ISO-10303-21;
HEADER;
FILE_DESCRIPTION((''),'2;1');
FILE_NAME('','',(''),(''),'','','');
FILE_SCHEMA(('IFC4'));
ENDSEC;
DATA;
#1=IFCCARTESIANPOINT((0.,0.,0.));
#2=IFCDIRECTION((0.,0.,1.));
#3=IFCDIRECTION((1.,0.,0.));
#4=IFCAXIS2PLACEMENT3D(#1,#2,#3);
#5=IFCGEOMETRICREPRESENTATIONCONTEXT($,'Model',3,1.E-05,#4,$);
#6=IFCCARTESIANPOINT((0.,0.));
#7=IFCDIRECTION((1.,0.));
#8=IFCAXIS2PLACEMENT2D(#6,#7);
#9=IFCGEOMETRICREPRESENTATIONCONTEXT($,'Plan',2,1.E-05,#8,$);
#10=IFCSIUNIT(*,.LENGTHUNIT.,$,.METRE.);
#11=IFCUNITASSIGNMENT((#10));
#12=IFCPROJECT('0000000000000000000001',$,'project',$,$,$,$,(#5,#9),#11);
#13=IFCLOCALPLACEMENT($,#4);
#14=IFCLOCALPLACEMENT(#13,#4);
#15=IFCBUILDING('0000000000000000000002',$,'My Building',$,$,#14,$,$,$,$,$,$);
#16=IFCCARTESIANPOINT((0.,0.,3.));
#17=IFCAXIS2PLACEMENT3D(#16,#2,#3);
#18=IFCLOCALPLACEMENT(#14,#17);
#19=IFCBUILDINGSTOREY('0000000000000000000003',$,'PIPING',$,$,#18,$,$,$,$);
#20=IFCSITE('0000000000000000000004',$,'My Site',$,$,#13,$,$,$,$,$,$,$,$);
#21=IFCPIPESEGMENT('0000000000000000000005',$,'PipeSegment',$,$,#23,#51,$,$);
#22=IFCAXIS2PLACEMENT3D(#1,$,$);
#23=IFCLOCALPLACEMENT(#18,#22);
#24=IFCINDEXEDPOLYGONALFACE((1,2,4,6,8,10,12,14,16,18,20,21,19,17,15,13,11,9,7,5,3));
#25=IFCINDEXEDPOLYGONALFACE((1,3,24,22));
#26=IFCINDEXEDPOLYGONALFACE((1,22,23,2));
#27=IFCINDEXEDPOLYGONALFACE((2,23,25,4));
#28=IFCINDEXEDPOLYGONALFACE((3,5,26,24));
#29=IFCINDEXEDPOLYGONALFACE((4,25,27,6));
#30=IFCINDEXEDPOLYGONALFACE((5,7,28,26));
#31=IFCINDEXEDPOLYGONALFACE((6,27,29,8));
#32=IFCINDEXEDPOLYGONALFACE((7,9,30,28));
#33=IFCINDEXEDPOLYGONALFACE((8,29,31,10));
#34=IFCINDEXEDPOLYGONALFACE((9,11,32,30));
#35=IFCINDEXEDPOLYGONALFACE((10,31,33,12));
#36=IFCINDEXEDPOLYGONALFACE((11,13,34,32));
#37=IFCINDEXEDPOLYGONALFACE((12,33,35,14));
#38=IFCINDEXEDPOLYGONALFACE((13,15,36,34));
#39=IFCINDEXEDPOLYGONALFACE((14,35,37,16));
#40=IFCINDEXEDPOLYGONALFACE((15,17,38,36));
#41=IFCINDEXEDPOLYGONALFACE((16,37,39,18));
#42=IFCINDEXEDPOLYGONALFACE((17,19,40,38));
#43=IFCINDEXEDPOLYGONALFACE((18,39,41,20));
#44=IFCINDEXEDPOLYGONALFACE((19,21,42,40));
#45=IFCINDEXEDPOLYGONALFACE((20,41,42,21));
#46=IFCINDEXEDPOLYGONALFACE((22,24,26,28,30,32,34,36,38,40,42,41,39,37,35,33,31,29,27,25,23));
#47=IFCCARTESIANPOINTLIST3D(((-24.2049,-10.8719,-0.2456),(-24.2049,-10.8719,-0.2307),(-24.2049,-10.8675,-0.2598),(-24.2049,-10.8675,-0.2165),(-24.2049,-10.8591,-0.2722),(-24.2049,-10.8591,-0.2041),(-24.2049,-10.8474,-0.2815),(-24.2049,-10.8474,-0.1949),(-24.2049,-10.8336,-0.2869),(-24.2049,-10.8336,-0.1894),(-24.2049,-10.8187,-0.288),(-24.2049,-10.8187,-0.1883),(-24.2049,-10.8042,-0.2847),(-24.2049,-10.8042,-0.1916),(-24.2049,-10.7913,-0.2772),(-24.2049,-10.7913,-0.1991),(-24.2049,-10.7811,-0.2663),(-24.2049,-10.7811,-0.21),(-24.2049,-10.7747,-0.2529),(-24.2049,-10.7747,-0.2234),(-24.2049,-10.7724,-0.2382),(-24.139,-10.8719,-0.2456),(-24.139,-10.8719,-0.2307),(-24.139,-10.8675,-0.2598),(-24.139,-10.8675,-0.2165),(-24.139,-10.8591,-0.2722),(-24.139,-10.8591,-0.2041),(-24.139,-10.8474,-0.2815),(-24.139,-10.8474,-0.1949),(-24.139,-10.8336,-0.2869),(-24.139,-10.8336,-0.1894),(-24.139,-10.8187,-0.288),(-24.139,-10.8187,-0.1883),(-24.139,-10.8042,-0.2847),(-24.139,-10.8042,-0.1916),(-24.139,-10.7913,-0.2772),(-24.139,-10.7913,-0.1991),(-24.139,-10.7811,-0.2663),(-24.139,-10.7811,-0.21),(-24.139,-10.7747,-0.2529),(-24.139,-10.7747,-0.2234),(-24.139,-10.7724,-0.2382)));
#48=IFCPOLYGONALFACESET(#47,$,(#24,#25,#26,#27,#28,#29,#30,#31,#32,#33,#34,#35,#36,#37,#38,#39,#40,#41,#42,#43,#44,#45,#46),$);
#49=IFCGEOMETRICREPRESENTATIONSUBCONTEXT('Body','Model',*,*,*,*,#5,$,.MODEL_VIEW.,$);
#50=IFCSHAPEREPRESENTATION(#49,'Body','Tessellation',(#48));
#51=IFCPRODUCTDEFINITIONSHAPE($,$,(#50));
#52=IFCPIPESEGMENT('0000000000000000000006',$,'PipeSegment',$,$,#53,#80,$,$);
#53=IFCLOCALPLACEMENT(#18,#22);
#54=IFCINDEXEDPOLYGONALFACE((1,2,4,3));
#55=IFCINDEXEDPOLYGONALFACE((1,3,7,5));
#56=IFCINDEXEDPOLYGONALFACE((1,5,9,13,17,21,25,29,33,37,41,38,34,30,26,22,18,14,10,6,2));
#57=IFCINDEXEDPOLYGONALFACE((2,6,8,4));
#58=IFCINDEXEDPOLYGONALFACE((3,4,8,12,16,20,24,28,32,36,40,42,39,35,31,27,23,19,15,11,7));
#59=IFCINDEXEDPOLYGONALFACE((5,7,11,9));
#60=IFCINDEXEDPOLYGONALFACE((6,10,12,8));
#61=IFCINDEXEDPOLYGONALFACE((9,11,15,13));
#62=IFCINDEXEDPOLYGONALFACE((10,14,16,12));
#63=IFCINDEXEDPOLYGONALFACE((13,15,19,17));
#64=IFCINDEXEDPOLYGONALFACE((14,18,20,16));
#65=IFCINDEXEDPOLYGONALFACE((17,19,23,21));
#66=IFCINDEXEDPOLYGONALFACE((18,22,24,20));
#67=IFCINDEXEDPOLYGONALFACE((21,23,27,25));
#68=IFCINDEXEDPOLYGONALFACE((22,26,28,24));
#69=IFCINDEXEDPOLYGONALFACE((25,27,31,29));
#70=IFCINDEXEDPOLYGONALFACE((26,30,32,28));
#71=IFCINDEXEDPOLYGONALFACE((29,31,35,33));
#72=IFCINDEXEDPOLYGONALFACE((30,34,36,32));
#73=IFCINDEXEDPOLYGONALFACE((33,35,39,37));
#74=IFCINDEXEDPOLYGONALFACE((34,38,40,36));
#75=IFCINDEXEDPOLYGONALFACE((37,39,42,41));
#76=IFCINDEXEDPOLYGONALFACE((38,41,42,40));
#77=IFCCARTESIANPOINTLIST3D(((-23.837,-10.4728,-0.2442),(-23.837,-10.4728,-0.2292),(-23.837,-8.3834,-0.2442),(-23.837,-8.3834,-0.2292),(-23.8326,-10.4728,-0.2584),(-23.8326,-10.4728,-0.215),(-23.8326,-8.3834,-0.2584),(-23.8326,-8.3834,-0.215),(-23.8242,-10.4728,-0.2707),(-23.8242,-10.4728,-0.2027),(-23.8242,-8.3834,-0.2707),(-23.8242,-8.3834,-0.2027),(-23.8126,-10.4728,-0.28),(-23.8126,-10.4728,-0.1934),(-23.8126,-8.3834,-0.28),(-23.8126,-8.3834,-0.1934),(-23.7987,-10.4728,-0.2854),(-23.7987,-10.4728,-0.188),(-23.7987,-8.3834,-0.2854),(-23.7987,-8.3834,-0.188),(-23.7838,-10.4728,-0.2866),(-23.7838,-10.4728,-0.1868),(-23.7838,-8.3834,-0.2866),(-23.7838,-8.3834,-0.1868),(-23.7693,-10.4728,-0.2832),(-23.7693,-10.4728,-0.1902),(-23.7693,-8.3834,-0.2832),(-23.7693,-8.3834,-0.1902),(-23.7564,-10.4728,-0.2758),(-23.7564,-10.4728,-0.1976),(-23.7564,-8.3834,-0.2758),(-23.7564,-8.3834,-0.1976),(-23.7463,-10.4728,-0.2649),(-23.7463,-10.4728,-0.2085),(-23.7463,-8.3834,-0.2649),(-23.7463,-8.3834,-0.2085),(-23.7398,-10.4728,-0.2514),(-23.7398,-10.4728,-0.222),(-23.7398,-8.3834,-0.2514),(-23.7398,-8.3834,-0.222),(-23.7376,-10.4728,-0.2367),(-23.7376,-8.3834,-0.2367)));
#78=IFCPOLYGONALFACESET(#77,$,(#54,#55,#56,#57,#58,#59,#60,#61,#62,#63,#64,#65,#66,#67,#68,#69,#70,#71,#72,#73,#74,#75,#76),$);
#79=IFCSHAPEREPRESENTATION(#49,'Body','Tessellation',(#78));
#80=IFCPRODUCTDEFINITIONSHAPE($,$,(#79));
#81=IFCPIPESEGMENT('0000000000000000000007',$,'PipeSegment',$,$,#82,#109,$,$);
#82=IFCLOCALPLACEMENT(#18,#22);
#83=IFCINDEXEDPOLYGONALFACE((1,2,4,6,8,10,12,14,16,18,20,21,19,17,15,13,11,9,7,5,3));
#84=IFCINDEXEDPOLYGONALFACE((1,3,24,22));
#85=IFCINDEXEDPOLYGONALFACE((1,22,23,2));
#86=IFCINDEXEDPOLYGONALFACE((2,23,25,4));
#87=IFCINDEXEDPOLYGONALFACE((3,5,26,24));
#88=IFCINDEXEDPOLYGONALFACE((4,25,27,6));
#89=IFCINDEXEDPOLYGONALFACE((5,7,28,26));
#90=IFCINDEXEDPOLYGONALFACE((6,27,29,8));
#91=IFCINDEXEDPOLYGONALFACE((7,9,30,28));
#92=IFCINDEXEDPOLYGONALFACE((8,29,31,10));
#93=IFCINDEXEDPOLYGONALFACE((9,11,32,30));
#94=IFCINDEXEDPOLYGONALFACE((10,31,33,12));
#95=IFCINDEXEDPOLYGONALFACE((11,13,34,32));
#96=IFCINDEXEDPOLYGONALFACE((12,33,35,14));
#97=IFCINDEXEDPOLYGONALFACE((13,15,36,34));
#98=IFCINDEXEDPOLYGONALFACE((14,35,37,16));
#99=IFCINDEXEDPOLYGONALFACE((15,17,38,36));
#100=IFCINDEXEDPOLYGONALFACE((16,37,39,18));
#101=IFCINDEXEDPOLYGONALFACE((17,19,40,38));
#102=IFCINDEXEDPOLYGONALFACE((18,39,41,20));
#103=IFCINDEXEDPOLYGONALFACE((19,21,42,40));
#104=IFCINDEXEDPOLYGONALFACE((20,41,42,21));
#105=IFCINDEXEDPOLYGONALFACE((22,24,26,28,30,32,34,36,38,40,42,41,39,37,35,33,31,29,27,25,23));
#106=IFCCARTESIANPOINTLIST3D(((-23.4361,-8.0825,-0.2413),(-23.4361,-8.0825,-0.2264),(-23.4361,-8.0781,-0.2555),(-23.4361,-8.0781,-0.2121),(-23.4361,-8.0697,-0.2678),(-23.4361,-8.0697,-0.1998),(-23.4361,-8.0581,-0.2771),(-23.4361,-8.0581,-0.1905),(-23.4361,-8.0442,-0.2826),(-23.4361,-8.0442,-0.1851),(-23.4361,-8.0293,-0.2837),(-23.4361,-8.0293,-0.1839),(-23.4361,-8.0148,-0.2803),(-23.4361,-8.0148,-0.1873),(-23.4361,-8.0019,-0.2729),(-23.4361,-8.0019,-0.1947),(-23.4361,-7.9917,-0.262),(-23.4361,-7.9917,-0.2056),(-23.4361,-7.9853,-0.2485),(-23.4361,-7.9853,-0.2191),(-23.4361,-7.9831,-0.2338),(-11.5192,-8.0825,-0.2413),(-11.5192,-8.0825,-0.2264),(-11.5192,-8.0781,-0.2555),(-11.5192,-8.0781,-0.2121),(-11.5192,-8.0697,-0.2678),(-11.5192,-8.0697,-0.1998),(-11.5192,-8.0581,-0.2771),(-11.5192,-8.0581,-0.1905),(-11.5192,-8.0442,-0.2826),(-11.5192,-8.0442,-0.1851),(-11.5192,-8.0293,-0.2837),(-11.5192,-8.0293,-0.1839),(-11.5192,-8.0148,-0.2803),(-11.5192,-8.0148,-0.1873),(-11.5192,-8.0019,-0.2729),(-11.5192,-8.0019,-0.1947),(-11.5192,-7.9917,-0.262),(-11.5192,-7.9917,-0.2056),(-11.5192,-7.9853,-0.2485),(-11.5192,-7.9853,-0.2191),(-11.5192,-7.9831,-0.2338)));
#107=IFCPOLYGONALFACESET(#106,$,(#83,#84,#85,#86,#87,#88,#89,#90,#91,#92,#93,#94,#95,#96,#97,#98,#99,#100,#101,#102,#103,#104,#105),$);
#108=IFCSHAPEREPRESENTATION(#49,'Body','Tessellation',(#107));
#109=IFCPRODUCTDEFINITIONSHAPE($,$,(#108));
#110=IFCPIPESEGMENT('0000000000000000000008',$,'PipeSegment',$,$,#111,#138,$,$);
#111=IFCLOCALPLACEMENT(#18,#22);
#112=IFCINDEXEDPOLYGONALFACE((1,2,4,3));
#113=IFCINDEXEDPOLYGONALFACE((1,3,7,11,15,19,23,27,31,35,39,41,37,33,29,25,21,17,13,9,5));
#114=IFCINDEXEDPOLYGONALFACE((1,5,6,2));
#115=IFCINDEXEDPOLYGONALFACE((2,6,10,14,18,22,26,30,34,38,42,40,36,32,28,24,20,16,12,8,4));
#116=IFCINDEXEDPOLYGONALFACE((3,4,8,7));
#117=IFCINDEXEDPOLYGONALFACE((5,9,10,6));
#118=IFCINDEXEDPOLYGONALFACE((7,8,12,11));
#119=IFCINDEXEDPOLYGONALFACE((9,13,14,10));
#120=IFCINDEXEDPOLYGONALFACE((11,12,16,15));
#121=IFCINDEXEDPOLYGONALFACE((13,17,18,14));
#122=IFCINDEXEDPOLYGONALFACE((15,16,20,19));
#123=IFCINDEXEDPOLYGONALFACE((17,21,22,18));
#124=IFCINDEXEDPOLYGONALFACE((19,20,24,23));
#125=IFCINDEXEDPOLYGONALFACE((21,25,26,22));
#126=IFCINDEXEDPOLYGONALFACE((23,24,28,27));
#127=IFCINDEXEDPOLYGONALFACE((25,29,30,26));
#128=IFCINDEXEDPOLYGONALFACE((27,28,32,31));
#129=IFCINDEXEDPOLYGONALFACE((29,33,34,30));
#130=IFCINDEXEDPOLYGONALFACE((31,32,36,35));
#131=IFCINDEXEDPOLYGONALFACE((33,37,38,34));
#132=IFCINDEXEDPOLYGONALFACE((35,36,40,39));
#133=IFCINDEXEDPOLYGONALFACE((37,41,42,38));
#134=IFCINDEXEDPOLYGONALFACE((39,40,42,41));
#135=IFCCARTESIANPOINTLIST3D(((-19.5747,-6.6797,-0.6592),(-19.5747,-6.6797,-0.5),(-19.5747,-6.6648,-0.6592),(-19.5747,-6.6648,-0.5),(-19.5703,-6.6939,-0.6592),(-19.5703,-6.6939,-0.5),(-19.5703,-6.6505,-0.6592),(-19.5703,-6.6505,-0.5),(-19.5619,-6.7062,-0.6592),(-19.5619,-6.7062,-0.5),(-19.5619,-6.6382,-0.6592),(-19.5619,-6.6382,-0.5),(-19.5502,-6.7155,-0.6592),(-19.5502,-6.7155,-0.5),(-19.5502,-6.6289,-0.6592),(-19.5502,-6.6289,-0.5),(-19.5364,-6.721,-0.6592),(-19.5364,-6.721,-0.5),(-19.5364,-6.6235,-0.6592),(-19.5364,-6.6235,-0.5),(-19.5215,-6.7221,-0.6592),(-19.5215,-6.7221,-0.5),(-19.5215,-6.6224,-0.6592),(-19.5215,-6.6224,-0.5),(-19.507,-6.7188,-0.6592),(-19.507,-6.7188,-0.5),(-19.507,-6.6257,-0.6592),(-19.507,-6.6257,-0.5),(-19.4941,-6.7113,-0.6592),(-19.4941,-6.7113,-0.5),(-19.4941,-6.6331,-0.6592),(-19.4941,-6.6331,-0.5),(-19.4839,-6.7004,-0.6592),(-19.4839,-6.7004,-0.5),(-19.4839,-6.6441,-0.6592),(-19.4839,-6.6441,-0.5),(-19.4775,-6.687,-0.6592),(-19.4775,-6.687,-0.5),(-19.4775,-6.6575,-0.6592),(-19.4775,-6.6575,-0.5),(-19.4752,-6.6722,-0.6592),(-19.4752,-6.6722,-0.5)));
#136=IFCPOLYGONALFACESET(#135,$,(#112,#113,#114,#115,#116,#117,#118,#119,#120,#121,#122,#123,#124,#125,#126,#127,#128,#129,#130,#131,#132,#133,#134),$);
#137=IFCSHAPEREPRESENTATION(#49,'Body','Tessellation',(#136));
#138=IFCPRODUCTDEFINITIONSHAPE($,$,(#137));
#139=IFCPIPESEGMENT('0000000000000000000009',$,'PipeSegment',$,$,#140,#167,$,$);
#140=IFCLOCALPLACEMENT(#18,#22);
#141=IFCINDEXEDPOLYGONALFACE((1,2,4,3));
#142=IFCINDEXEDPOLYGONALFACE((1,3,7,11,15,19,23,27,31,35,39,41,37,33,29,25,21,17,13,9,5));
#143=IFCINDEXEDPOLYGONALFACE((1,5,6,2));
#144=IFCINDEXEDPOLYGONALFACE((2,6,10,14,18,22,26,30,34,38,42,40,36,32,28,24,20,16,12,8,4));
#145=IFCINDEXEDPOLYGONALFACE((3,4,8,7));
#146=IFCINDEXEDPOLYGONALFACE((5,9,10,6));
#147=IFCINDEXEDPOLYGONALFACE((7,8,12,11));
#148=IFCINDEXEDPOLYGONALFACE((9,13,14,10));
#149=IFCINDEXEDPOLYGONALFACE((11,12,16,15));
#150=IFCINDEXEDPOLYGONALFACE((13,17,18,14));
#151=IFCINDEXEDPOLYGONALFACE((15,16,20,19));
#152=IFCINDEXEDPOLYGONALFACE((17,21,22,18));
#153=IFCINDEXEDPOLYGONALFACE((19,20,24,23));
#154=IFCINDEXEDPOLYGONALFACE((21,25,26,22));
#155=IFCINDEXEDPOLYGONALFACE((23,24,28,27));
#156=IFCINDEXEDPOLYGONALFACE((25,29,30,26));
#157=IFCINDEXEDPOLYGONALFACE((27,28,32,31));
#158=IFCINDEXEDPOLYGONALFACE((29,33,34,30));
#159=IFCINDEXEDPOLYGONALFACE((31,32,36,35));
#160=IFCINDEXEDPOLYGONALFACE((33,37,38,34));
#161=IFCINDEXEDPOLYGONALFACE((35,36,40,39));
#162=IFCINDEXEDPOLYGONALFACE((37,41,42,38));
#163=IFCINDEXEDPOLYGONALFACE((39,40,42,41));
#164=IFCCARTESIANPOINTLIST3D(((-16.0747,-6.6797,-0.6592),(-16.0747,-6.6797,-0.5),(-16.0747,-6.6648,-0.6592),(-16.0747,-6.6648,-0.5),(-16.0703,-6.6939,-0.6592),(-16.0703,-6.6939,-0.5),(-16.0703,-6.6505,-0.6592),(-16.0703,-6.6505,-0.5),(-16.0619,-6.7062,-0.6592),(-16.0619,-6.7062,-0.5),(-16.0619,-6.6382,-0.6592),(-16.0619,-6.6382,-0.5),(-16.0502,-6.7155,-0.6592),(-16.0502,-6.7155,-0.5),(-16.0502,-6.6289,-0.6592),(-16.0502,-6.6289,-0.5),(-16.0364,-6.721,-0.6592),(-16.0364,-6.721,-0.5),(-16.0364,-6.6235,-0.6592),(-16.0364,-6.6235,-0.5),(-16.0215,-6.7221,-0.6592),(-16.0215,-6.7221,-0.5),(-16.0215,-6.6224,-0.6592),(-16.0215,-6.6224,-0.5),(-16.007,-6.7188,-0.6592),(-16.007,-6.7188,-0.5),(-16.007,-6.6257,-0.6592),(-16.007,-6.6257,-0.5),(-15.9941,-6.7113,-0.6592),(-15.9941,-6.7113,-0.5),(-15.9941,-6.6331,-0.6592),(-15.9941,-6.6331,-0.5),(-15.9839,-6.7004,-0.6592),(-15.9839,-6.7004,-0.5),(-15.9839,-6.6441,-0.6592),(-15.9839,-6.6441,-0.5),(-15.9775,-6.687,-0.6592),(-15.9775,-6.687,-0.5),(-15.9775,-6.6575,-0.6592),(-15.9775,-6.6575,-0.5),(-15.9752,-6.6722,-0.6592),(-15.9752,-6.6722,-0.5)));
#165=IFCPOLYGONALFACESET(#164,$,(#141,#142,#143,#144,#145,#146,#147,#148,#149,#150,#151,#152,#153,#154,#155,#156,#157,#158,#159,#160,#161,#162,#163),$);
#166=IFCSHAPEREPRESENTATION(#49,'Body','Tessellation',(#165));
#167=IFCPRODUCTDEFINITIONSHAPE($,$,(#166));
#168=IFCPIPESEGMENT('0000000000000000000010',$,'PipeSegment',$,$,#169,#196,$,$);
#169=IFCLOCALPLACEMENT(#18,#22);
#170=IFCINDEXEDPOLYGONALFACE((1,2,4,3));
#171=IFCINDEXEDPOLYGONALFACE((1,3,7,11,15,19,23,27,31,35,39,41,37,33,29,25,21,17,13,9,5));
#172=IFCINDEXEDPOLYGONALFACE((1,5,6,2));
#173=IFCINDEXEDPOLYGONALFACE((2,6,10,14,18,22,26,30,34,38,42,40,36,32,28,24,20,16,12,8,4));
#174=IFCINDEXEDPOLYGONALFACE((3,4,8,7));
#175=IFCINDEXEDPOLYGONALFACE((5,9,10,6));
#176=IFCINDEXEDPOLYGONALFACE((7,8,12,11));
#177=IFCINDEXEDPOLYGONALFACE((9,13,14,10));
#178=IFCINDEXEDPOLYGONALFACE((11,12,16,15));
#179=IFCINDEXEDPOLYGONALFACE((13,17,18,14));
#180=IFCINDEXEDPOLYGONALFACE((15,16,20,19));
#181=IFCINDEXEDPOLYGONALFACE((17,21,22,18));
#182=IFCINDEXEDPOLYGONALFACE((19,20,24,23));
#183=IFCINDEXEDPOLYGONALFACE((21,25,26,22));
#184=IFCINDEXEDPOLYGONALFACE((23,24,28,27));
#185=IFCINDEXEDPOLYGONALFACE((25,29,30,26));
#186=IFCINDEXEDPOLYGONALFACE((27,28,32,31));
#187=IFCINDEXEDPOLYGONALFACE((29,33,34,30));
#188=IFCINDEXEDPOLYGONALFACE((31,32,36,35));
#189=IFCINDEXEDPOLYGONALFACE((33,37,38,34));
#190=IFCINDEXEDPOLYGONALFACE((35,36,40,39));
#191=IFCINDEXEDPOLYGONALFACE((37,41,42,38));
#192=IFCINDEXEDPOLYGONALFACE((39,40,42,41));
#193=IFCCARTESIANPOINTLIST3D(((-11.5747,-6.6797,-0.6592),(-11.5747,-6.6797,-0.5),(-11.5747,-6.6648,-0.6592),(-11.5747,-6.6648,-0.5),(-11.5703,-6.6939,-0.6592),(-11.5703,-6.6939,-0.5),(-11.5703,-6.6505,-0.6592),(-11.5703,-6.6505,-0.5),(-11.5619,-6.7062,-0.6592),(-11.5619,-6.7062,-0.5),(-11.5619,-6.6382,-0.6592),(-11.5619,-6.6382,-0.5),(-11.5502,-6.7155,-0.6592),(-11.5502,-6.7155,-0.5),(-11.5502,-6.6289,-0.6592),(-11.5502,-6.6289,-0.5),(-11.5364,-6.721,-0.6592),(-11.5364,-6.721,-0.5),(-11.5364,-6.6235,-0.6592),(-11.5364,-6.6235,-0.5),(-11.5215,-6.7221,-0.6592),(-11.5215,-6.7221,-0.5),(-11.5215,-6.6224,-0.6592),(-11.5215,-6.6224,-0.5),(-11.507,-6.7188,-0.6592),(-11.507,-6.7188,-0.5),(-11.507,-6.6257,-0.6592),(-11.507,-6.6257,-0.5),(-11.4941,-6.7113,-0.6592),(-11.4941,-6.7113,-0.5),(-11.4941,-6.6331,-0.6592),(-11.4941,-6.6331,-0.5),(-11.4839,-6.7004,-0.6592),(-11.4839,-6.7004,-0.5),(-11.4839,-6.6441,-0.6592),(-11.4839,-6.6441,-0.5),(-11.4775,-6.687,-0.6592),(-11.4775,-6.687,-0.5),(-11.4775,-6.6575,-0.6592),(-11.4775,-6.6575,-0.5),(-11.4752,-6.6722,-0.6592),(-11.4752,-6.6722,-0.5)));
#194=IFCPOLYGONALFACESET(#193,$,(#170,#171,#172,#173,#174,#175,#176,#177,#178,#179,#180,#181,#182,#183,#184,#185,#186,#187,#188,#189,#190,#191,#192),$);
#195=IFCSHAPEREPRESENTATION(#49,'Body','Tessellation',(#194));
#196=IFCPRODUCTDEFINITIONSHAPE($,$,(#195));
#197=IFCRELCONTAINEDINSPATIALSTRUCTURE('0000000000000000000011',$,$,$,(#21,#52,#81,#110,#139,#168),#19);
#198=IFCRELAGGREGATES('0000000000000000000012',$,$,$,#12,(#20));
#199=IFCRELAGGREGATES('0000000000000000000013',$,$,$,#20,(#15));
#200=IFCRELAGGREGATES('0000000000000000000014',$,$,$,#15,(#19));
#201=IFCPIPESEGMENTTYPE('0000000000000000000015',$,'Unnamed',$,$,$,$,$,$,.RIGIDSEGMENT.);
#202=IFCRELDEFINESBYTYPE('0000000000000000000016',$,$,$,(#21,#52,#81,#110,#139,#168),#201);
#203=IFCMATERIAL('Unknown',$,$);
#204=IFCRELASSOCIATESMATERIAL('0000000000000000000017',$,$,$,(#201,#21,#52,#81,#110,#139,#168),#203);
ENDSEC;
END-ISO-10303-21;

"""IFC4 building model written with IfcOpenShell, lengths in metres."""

from ifc_helpers import new_model, si_unit, frame, origin_with_axes, origin_2d_with_axis, place, context, subcontext, project, spatial, circle, extrude, material, material_profile, profile_set, profile_usage, type_object, element, save


model = new_model("IFC4")

# Units and contexts
model_context = context("Model", 3, precision=1e-05, world=origin_with_axes())
plan_context = context("Plan", 2, precision=1e-05, world=origin_2d_with_axis())
body_context = subcontext(model_context, "Body", "Model", "MODEL_VIEW")
ifc_project = project(units=[si_unit("LENGTHUNIT", "METRE")], contexts=[model_context, plan_context])

# Site, building, storey
site_placement = place(None, origin_with_axes())
site = spatial("IfcSite", under=ifc_project, at=site_placement, Name="My Site")
building_placement = place(site_placement, origin_with_axes())
building = spatial("IfcBuilding", under=site, at=building_placement, Name="My Building")
storey_placement = place(building_placement, frame((0.0, 0.0, 3.0), z_axis=(0.0, 0.0, 1.0), x_axis=(1.0, 0.0, 0.0)))
storey = spatial("IfcBuildingStorey", under=building, at=storey_placement, Name="PIPING")

# Pipe segments
ifc_material = material(Name="Unknown")
ifc_material_profile = material_profile(ifc_material, circle(Radius=0.05))
ifc_profile_set = profile_set([ifc_material_profile])
pipe_segment_type = type_object("IfcPipeSegmentType", Name="Unnamed", PredefinedType="RIGIDSEGMENT", material=ifc_profile_set)
ifc_profile_usage_1 = profile_usage(ifc_profile_set, cardinal=5)
pipe_segment_1_placement = place(storey_placement, frame((-24.2049, -10.8224, -0.2382), z_axis=(1.0, 0.0, 0.0), x_axis=(0.0, 1.0, 0.0)))
element("IfcPipeSegment", 1, at=pipe_segment_1_placement, inside=storey, type_object=pipe_segment_type, material=ifc_profile_usage_1, Name="PipeSegment", context=body_context, shape_type="SweptSolid", body=[
    extrude(circle(Radius=0.05), origin_with_axes(), (0.0, 0.0, 1.0), 0.0658),
])
ifc_profile_usage_2 = profile_usage(ifc_profile_set, cardinal=5)
pipe_segment_2_placement = place(storey_placement, frame((-23.7876, -8.3834, -0.2367), z_axis=(0.0, -1.0, 0.0), x_axis=(1.0, 0.0, 0.0)))
element("IfcPipeSegment", 2, at=pipe_segment_2_placement, inside=storey, type_object=pipe_segment_type, material=ifc_profile_usage_2, Name="PipeSegment", context=body_context, shape_type="SweptSolid", body=[
    extrude(circle(Radius=0.05), origin_with_axes(), (0.0, 0.0, 1.0), 2.0894),
])
ifc_profile_usage_3 = profile_usage(ifc_profile_set, cardinal=5)
pipe_segment_3_placement = place(storey_placement, frame((-23.4361, -8.0331, -0.2338), z_axis=(1.0, 0.0, 0.0), x_axis=(0.0, 1.0, 0.0)))
element("IfcPipeSegment", 3, at=pipe_segment_3_placement, inside=storey, type_object=pipe_segment_type, material=ifc_profile_usage_3, Name="PipeSegment", context=body_context, shape_type="SweptSolid", body=[
    extrude(circle(Radius=0.05), origin_with_axes(), (0.0, 0.0, 1.0), 11.9169),
])
ifc_profile_usage_4 = profile_usage(ifc_profile_set, cardinal=5)
pipe_segment_4_placement = place(storey_placement, frame((-19.5252, -6.6722, -0.5), z_axis=(0.0, 0.0, -1.0), x_axis=(1.0, 0.0, 0.0)))
element("IfcPipeSegment", 4, at=pipe_segment_4_placement, inside=storey, type_object=pipe_segment_type, material=ifc_profile_usage_4, Name="PipeSegment", context=body_context, shape_type="SweptSolid", body=[
    extrude(circle(Radius=0.05), origin_with_axes(), (0.0, 0.0, 1.0), 0.1592),
])
ifc_profile_usage_5 = profile_usage(ifc_profile_set, cardinal=5)
pipe_segment_5_placement = place(storey_placement, frame((-16.0252, -6.6722, -0.5), z_axis=(0.0, 0.0, -1.0), x_axis=(1.0, 0.0, 0.0)))
element("IfcPipeSegment", 5, at=pipe_segment_5_placement, inside=storey, type_object=pipe_segment_type, material=ifc_profile_usage_5, Name="PipeSegment", context=body_context, shape_type="SweptSolid", body=[
    extrude(circle(Radius=0.05), origin_with_axes(), (0.0, 0.0, 1.0), 0.1592),
])
ifc_profile_usage_6 = profile_usage(ifc_profile_set, cardinal=5)
pipe_segment_6_placement = place(storey_placement, frame((-11.5252, -6.6722, -0.5), z_axis=(0.0, 0.0, -1.0), x_axis=(1.0, 0.0, 0.0)))
element("IfcPipeSegment", 6, at=pipe_segment_6_placement, inside=storey, type_object=pipe_segment_type, material=ifc_profile_usage_6, Name="PipeSegment", context=body_context, shape_type="SweptSolid", body=[
    extrude(circle(Radius=0.05), origin_with_axes(), (0.0, 0.0, 1.0), 0.1592),
])

save(model, "model.ifc")
